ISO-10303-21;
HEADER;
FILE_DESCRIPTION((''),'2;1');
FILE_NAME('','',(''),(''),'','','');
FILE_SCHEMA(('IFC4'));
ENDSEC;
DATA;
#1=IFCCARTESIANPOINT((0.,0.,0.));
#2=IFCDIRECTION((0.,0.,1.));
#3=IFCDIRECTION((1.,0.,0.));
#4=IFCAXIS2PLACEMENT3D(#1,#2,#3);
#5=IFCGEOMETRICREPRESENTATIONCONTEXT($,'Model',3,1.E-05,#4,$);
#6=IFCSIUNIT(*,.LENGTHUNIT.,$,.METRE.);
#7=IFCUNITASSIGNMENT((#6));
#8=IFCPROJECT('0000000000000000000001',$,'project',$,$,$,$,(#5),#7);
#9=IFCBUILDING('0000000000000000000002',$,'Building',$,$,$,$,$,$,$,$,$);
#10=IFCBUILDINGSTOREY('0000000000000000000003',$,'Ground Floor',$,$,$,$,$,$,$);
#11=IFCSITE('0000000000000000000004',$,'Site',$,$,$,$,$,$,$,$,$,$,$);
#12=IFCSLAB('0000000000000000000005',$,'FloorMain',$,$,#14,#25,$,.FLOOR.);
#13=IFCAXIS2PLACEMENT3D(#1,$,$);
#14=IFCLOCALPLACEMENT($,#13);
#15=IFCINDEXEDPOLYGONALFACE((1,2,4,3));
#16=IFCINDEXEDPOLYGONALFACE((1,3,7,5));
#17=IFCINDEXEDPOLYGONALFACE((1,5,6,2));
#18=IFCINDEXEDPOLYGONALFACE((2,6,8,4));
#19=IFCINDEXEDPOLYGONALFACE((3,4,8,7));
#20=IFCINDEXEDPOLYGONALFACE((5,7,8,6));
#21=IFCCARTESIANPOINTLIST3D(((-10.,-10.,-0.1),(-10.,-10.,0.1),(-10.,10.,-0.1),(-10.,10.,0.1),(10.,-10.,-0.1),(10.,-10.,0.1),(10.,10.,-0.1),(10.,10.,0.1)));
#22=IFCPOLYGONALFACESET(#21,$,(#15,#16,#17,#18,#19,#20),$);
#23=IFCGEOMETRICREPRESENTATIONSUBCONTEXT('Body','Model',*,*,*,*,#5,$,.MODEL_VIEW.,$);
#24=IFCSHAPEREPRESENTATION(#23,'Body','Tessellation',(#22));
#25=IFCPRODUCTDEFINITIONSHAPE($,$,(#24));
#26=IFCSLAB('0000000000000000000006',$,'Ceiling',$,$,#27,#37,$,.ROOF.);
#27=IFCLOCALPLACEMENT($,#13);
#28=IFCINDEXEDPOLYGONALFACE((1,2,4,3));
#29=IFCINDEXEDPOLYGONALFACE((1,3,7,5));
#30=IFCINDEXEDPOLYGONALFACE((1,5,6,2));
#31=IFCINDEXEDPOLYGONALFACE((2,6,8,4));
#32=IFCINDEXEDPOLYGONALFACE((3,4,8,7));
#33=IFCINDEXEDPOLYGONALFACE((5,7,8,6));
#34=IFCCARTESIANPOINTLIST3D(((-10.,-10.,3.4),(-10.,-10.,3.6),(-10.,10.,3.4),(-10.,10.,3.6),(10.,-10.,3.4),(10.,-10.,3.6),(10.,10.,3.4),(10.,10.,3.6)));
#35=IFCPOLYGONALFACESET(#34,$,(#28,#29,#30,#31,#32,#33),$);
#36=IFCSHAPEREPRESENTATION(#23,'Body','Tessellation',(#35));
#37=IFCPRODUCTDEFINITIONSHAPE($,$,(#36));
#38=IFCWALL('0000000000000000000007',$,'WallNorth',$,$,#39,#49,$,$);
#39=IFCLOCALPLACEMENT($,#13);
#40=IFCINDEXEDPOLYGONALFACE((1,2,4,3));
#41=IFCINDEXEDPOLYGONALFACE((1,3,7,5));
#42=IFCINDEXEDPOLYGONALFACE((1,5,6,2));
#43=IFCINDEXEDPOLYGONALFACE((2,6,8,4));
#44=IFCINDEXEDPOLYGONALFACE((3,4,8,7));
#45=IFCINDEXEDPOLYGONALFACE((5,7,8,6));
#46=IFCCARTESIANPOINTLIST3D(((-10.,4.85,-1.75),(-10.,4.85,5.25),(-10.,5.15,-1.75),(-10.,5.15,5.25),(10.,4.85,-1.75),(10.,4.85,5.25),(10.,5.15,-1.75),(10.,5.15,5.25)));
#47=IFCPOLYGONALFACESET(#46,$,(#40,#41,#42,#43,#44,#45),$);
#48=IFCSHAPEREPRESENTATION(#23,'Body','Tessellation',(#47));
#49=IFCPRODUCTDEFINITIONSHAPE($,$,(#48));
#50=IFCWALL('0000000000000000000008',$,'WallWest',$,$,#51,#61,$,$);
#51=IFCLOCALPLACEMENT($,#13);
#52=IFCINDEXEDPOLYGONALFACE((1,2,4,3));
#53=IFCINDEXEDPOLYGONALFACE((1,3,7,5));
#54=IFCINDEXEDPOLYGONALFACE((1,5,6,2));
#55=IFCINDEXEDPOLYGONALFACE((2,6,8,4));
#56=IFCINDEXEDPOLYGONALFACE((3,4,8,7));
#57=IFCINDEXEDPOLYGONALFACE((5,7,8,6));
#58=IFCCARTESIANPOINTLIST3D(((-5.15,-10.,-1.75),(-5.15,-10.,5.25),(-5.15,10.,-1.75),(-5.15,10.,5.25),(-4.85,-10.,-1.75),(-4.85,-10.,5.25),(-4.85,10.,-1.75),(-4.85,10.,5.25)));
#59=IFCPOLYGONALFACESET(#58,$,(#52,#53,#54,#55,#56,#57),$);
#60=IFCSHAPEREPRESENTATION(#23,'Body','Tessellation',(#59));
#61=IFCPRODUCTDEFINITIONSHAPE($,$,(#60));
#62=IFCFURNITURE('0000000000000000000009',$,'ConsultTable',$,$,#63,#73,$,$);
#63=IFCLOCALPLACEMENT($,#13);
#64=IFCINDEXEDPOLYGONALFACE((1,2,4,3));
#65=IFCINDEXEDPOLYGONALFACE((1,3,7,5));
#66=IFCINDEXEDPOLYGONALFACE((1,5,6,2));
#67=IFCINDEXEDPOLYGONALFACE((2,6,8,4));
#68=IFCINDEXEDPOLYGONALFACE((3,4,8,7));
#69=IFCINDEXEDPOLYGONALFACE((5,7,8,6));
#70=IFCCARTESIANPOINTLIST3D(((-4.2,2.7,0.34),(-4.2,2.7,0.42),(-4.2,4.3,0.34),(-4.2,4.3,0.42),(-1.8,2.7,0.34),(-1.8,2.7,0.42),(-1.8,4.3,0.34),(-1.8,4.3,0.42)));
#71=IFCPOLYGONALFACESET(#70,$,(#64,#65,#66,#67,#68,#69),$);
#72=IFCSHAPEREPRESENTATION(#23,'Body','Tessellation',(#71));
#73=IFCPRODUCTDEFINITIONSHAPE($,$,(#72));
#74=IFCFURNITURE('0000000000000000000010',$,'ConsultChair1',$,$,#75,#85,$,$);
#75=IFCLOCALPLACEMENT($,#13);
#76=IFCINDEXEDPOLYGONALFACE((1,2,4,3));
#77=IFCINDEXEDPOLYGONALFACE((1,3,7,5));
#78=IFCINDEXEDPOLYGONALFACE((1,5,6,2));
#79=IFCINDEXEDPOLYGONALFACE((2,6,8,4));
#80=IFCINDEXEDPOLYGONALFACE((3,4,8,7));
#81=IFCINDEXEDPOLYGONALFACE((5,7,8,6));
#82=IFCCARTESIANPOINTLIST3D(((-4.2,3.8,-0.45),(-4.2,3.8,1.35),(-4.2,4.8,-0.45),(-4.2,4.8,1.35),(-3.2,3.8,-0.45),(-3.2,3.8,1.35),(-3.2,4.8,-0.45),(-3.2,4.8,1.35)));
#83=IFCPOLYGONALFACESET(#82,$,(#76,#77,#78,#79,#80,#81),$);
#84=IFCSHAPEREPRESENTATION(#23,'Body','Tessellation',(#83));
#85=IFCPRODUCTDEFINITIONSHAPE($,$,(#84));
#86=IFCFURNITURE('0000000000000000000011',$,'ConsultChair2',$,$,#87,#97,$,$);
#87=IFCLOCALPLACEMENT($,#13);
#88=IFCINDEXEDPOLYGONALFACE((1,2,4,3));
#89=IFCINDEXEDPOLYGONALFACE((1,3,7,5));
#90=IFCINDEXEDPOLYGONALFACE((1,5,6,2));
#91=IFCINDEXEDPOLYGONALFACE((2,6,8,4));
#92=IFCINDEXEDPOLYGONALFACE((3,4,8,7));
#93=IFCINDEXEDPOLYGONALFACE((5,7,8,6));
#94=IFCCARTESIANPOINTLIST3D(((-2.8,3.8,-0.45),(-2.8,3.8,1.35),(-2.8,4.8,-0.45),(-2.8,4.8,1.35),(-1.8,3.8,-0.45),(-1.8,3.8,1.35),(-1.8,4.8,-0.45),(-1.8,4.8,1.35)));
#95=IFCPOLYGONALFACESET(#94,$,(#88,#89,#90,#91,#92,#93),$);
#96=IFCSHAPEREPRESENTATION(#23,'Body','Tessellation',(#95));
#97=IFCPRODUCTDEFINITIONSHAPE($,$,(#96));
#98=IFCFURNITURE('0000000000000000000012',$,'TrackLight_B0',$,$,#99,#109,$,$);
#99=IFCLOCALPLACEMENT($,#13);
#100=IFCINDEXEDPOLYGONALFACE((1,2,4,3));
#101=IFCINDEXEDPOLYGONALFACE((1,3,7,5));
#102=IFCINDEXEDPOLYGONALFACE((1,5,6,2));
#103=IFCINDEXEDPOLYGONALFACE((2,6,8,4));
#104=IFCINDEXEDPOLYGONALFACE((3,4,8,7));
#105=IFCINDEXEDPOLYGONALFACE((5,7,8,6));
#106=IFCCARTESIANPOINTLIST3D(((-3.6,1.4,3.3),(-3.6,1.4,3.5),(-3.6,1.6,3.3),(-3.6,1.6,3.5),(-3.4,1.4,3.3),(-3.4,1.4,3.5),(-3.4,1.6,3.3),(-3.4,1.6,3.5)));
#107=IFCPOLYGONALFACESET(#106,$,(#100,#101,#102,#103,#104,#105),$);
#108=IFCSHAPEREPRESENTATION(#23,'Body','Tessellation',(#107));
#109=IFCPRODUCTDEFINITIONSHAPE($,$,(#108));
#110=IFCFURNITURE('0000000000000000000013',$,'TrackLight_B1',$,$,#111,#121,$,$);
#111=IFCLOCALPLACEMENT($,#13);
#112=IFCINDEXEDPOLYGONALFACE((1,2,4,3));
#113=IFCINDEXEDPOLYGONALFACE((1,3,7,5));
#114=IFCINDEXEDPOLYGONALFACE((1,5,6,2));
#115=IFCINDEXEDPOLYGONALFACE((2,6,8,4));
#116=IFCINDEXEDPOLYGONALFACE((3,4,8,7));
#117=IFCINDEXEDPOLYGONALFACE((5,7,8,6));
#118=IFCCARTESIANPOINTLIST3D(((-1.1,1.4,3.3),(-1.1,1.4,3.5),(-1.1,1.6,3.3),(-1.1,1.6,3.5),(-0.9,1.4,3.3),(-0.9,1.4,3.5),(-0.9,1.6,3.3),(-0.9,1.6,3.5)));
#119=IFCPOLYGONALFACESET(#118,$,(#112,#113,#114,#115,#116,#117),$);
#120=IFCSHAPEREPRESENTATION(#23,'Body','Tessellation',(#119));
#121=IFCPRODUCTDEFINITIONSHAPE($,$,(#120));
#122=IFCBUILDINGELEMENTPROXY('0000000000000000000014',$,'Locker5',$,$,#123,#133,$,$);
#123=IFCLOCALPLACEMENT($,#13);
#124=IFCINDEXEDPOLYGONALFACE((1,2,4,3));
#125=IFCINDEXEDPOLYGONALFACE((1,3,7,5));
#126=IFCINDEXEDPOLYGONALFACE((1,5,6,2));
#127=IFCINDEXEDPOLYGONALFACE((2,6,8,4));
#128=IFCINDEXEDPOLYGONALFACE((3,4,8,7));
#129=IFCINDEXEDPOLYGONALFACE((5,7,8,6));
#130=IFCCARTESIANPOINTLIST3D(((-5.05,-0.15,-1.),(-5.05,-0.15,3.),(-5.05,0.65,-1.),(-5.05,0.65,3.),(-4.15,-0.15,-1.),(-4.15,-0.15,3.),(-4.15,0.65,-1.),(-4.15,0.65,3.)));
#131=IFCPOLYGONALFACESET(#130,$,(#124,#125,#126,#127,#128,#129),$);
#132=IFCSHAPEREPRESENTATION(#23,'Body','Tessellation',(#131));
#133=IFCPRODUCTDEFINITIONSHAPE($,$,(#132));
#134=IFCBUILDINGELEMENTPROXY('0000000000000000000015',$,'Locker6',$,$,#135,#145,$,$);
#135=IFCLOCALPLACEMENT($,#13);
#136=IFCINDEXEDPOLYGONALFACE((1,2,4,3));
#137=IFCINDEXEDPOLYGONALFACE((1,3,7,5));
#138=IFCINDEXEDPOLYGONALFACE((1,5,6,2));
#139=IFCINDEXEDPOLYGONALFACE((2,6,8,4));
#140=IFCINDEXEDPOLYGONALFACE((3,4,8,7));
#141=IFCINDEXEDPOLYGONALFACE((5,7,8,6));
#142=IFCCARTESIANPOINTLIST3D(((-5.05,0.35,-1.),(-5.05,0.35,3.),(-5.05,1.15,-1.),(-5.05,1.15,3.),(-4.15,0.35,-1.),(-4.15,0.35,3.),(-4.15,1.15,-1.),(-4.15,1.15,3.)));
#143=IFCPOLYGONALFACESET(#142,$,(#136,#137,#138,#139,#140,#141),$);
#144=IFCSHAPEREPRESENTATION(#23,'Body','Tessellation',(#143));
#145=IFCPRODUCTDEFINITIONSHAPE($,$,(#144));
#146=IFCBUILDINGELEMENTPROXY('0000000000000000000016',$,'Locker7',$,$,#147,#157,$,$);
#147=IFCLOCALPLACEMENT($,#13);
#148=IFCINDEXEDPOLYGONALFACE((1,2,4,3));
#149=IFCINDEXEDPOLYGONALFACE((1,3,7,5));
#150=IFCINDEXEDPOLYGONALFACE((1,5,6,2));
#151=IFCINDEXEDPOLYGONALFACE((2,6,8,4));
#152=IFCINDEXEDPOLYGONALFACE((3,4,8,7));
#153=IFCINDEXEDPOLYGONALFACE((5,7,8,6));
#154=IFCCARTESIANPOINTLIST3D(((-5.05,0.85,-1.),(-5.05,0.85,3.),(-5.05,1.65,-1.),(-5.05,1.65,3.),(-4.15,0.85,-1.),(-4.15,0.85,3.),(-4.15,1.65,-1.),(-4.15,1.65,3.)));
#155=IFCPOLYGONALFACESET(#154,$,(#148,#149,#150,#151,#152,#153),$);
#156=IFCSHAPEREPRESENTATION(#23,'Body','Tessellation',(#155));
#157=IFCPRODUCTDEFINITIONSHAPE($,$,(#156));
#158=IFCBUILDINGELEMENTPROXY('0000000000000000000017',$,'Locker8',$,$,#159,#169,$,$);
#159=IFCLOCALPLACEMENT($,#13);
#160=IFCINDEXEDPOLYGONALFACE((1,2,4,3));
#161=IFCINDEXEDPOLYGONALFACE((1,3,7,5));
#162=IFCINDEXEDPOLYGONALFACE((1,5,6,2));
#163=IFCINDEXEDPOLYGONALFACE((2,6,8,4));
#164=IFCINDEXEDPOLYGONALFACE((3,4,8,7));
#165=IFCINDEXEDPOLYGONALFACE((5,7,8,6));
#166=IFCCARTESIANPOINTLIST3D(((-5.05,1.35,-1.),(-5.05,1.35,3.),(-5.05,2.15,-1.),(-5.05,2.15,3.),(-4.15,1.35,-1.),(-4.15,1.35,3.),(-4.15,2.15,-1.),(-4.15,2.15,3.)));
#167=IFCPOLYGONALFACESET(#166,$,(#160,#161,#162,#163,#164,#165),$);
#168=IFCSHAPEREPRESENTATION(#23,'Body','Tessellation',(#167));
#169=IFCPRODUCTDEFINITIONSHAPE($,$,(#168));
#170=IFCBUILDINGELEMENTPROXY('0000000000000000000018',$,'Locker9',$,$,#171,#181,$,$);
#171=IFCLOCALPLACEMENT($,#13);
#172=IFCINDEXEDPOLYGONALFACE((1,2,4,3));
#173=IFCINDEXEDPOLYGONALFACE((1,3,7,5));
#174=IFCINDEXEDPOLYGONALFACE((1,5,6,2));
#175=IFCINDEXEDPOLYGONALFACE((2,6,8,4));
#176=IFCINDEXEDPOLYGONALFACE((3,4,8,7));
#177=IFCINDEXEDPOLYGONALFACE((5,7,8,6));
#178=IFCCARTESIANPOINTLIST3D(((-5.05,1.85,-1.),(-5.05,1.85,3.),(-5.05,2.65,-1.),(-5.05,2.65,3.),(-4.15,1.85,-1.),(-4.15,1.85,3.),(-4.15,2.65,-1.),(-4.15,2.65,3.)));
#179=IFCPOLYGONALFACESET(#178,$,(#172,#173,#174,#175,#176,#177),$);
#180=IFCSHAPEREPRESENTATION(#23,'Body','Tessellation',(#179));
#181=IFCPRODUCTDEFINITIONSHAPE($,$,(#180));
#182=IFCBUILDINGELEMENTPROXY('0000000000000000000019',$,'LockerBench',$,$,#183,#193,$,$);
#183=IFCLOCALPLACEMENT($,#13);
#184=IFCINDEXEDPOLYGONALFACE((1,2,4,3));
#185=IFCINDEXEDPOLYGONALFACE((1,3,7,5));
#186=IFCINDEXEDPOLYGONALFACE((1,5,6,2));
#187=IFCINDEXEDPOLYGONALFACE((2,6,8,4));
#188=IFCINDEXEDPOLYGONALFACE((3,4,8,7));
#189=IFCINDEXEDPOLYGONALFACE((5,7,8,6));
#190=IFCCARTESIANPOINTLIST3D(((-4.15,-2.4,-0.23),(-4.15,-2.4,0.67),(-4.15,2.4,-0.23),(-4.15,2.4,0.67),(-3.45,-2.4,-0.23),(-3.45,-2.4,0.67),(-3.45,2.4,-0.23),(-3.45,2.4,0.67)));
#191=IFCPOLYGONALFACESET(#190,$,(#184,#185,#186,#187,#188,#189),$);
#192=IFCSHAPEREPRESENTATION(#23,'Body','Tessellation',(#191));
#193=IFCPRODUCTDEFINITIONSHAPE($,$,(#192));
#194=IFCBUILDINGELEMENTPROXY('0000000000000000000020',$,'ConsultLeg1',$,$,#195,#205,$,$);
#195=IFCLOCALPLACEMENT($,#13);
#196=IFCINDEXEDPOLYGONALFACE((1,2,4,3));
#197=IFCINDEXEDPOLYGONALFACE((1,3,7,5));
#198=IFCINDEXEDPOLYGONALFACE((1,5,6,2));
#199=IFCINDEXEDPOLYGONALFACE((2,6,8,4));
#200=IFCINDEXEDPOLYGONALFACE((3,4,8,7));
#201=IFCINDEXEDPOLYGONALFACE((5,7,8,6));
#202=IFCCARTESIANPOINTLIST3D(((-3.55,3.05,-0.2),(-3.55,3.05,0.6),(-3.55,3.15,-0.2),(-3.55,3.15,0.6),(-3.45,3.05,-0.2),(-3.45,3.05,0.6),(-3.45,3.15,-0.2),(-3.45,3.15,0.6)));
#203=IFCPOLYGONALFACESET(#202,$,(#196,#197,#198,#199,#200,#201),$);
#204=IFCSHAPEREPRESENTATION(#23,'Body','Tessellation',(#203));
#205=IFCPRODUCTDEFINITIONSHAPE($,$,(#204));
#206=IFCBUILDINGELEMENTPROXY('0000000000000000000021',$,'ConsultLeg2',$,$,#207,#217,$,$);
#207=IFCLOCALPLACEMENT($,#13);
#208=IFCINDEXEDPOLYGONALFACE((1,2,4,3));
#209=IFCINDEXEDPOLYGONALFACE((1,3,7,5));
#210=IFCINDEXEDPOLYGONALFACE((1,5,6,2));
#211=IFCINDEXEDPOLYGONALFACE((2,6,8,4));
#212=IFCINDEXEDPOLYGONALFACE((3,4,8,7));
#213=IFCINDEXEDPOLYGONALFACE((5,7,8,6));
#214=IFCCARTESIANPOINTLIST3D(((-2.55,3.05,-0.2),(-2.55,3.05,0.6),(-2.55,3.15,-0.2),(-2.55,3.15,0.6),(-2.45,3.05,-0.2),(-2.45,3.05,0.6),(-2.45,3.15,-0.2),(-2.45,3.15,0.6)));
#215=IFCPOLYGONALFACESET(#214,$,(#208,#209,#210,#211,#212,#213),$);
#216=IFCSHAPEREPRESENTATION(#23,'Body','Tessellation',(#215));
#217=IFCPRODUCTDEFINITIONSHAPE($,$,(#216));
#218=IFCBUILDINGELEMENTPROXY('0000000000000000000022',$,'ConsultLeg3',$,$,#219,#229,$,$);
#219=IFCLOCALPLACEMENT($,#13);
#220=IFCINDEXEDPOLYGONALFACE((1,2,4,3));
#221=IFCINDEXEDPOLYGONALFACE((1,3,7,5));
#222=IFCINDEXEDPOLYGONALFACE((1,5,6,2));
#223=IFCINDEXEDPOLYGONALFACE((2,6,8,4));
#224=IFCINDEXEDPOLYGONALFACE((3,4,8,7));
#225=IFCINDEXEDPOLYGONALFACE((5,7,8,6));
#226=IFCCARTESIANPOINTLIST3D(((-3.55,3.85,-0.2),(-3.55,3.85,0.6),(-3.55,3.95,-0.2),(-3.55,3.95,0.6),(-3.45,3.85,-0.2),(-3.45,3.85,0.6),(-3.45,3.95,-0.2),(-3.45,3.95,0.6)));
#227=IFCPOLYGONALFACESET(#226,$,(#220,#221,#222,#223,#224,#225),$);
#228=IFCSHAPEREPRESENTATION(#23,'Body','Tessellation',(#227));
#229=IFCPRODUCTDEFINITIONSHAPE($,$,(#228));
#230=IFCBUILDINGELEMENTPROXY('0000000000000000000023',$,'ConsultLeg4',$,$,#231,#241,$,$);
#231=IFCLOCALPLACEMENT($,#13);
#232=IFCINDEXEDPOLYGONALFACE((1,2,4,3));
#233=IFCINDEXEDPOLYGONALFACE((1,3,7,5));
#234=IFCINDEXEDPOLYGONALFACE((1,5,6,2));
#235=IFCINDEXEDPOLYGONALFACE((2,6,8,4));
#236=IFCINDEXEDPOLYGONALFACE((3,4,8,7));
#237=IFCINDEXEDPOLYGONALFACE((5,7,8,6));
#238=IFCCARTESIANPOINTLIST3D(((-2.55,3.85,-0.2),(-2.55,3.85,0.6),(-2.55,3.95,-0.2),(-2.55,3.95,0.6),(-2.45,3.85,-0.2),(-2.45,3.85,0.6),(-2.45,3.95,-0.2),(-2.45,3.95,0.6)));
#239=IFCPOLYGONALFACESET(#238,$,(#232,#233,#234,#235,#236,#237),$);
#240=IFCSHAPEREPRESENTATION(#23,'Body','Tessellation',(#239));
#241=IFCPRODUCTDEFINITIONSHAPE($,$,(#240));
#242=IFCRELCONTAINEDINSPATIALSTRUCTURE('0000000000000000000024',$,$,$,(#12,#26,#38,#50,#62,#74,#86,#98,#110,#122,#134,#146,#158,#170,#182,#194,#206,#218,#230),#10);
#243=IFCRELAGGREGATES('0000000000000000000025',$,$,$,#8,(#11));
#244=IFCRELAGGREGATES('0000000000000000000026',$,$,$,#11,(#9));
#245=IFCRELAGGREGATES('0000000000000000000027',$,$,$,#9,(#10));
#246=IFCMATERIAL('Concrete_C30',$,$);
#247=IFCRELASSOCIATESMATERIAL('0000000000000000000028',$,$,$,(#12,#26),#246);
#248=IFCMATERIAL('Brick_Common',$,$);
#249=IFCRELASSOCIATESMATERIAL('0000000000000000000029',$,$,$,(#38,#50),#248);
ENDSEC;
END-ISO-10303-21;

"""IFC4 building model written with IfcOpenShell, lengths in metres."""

from ifc_helpers import new_model, si_unit, frame, origin_with_axes, origin_2d, place, context, subcontext, project, spatial, rectangle, extrude, material, element, save


model = new_model("IFC4")

# Units and contexts
model_context = context("Model", 3, precision=1e-05, world=origin_with_axes())
body_context = subcontext(model_context, "Body", "Model", "MODEL_VIEW")
ifc_project = project(units=[si_unit("LENGTHUNIT", "METRE")], contexts=[model_context])

# Site, building, storey
site = spatial("IfcSite", under=ifc_project, Name="Site")
building = spatial("IfcBuilding", under=site, Name="Building")
storey = spatial("IfcBuildingStorey", under=building, Name="Ground Floor")

# Slabs
ifc_material_1 = material(Name="Concrete_C30")
slab_1_placement = place(None, origin_with_axes())
element("IfcSlab", 1, at=slab_1_placement, inside=storey, material=ifc_material_1, Name="FloorMain", PredefinedType="FLOOR", context=body_context, shape_type="SweptSolid", body=[
    extrude(rectangle(XDim=20.0, YDim=20.0, at=origin_2d()), frame((0.0, 0.0, -0.1)), (0.0, 0.0, 1.0), 0.2),
])
slab_2_placement = place(None, frame((0.0, 0.0, 3.5), z_axis=(0.0, 0.0, 1.0), x_axis=(1.0, 0.0, 0.0)))
element("IfcSlab", 2, at=slab_2_placement, inside=storey, material=ifc_material_1, Name="Ceiling", PredefinedType="ROOF", context=body_context, shape_type="SweptSolid", body=[
    extrude(rectangle(XDim=20.0, YDim=20.0, at=origin_2d()), frame((0.0, 0.0, -0.1)), (0.0, 0.0, 1.0), 0.2),
])

# Walls
ifc_material_2 = material(Name="Brick_Common")
wall_1_placement = place(None, frame((0.0, 5.0, 1.75), z_axis=(0.0, 0.0, 1.0), x_axis=(1.0, 0.0, 0.0)))
element("IfcWall", 3, at=wall_1_placement, inside=storey, material=ifc_material_2, Name="WallNorth", context=body_context, shape_type="SweptSolid", body=[
    extrude(rectangle(XDim=20.0, YDim=0.3, at=origin_2d()), frame((0.0, 0.0, -3.5)), (0.0, 0.0, 1.0), 7.0),
])
wall_2_placement = place(None, frame((-5.0, 0.0, 1.75), z_axis=(0.0, 0.0, 1.0), x_axis=(1.0, 0.0, 0.0)))
element("IfcWall", 4, at=wall_2_placement, inside=storey, material=ifc_material_2, Name="WallWest", context=body_context, shape_type="SweptSolid", body=[
    extrude(rectangle(XDim=0.3, YDim=20.0, at=origin_2d()), frame((0.0, 0.0, -3.5)), (0.0, 0.0, 1.0), 7.0),
])

# Furniture
furniture_placement = place(None, frame((-3.0, 3.5, 0.38), z_axis=(0.0, 0.0, 1.0), x_axis=(1.0, 0.0, 0.0)))
element("IfcFurniture", 5, at=furniture_placement, inside=storey, Name="ConsultTable", context=body_context, shape_type="SweptSolid", body=[
    extrude(rectangle(XDim=2.4, YDim=1.6, at=origin_2d()), frame((0.0, 0.0, -0.04)), (0.0, 0.0, 1.0), 0.08),
])
for number, where, z_axis, x_axis, name in (
    (6, (-3.7, 4.3, 0.45), (0.0, 0.0, 1.0), (1.0, 0.0, 0.0), "ConsultChair1"),
    (7, (-2.3, 4.3, 0.45), (0.0, 0.0, 1.0), (1.0, 0.0, 0.0), "ConsultChair2"),
):
    element("IfcFurniture", number, at=place(None, frame(where, z_axis=z_axis, x_axis=x_axis)), inside=storey, Name=name, context=body_context, shape_type="SweptSolid", body=[
        extrude(rectangle(XDim=1.0, YDim=1.0, at=origin_2d()), frame((0.0, 0.0, -0.9)), (0.0, 0.0, 1.0), 1.8),
    ])
for number, where, z_axis, x_axis, name in (
    (8, (-3.5, 1.5, 3.4), (0.0, 0.0, 1.0), (1.0, 0.0, 0.0), "TrackLight_B0"),
    (9, (-1.0, 1.5, 3.4), (0.0, 0.0, 1.0), (1.0, 0.0, 0.0), "TrackLight_B1"),
):
    element("IfcFurniture", number, at=place(None, frame(where, z_axis=z_axis, x_axis=x_axis)), inside=storey, Name=name, context=body_context, shape_type="SweptSolid", body=[
        extrude(rectangle(XDim=0.2, YDim=0.2, at=origin_2d()), frame((0.0, 0.0, -0.1)), (0.0, 0.0, 1.0), 0.2),
    ])

# Building element proxies
for number, where, z_axis, x_axis, name in (
    (10, (-4.6, 0.25, 1.0), (0.0, 0.0, 1.0), (1.0, 0.0, 0.0), "Locker5"),
    (11, (-4.6, 0.75, 1.0), (0.0, 0.0, 1.0), (1.0, 0.0, 0.0), "Locker6"),
    (12, (-4.6, 1.25, 1.0), (0.0, 0.0, 1.0), (1.0, 0.0, 0.0), "Locker7"),
    (13, (-4.6, 1.75, 1.0), (0.0, 0.0, 1.0), (1.0, 0.0, 0.0), "Locker8"),
    (14, (-4.6, 2.25, 1.0), (0.0, 0.0, 1.0), (1.0, 0.0, 0.0), "Locker9"),
):
    element("IfcBuildingElementProxy", number, at=place(None, frame(where, z_axis=z_axis, x_axis=x_axis)), inside=storey, Name=name, context=body_context, shape_type="SweptSolid", body=[
        extrude(rectangle(XDim=0.9, YDim=0.8, at=origin_2d()), frame((0.0, 0.0, -2.0)), (0.0, 0.0, 1.0), 4.0),
    ])
proxy_1_placement = place(None, frame((-3.8, 0.0, 0.22), z_axis=(0.0, 0.0, 1.0), x_axis=(1.0, 0.0, 0.0)))
element("IfcBuildingElementProxy", 15, at=proxy_1_placement, inside=storey, Name="LockerBench", context=body_context, shape_type="SweptSolid", body=[
    extrude(rectangle(XDim=0.7, YDim=4.8, at=origin_2d()), frame((0.0, 0.0, -0.45)), (0.0, 0.0, 1.0), 0.9),
])
for number, where, z_axis, x_axis, name in (
    (16, (-3.5, 3.1, 0.2), (0.0, 0.0, 1.0), (1.0, 0.0, 0.0), "ConsultLeg1"),
    (17, (-2.5, 3.1, 0.2), (0.0, 0.0, 1.0), (1.0, 0.0, 0.0), "ConsultLeg2"),
    (18, (-3.5, 3.9, 0.2), (0.0, 0.0, 1.0), (1.0, 0.0, 0.0), "ConsultLeg3"),
    (19, (-2.5, 3.9, 0.2), (0.0, 0.0, 1.0), (1.0, 0.0, 0.0), "ConsultLeg4"),
):
    element("IfcBuildingElementProxy", number, at=place(None, frame(where, z_axis=z_axis, x_axis=x_axis)), inside=storey, Name=name, context=body_context, shape_type="SweptSolid", body=[
        extrude(rectangle(XDim=0.1, YDim=0.1, at=origin_2d()), frame((0.0, 0.0, -0.4)), (0.0, 0.0, 1.0), 0.8),
    ])

save(model, "model.ifc")
